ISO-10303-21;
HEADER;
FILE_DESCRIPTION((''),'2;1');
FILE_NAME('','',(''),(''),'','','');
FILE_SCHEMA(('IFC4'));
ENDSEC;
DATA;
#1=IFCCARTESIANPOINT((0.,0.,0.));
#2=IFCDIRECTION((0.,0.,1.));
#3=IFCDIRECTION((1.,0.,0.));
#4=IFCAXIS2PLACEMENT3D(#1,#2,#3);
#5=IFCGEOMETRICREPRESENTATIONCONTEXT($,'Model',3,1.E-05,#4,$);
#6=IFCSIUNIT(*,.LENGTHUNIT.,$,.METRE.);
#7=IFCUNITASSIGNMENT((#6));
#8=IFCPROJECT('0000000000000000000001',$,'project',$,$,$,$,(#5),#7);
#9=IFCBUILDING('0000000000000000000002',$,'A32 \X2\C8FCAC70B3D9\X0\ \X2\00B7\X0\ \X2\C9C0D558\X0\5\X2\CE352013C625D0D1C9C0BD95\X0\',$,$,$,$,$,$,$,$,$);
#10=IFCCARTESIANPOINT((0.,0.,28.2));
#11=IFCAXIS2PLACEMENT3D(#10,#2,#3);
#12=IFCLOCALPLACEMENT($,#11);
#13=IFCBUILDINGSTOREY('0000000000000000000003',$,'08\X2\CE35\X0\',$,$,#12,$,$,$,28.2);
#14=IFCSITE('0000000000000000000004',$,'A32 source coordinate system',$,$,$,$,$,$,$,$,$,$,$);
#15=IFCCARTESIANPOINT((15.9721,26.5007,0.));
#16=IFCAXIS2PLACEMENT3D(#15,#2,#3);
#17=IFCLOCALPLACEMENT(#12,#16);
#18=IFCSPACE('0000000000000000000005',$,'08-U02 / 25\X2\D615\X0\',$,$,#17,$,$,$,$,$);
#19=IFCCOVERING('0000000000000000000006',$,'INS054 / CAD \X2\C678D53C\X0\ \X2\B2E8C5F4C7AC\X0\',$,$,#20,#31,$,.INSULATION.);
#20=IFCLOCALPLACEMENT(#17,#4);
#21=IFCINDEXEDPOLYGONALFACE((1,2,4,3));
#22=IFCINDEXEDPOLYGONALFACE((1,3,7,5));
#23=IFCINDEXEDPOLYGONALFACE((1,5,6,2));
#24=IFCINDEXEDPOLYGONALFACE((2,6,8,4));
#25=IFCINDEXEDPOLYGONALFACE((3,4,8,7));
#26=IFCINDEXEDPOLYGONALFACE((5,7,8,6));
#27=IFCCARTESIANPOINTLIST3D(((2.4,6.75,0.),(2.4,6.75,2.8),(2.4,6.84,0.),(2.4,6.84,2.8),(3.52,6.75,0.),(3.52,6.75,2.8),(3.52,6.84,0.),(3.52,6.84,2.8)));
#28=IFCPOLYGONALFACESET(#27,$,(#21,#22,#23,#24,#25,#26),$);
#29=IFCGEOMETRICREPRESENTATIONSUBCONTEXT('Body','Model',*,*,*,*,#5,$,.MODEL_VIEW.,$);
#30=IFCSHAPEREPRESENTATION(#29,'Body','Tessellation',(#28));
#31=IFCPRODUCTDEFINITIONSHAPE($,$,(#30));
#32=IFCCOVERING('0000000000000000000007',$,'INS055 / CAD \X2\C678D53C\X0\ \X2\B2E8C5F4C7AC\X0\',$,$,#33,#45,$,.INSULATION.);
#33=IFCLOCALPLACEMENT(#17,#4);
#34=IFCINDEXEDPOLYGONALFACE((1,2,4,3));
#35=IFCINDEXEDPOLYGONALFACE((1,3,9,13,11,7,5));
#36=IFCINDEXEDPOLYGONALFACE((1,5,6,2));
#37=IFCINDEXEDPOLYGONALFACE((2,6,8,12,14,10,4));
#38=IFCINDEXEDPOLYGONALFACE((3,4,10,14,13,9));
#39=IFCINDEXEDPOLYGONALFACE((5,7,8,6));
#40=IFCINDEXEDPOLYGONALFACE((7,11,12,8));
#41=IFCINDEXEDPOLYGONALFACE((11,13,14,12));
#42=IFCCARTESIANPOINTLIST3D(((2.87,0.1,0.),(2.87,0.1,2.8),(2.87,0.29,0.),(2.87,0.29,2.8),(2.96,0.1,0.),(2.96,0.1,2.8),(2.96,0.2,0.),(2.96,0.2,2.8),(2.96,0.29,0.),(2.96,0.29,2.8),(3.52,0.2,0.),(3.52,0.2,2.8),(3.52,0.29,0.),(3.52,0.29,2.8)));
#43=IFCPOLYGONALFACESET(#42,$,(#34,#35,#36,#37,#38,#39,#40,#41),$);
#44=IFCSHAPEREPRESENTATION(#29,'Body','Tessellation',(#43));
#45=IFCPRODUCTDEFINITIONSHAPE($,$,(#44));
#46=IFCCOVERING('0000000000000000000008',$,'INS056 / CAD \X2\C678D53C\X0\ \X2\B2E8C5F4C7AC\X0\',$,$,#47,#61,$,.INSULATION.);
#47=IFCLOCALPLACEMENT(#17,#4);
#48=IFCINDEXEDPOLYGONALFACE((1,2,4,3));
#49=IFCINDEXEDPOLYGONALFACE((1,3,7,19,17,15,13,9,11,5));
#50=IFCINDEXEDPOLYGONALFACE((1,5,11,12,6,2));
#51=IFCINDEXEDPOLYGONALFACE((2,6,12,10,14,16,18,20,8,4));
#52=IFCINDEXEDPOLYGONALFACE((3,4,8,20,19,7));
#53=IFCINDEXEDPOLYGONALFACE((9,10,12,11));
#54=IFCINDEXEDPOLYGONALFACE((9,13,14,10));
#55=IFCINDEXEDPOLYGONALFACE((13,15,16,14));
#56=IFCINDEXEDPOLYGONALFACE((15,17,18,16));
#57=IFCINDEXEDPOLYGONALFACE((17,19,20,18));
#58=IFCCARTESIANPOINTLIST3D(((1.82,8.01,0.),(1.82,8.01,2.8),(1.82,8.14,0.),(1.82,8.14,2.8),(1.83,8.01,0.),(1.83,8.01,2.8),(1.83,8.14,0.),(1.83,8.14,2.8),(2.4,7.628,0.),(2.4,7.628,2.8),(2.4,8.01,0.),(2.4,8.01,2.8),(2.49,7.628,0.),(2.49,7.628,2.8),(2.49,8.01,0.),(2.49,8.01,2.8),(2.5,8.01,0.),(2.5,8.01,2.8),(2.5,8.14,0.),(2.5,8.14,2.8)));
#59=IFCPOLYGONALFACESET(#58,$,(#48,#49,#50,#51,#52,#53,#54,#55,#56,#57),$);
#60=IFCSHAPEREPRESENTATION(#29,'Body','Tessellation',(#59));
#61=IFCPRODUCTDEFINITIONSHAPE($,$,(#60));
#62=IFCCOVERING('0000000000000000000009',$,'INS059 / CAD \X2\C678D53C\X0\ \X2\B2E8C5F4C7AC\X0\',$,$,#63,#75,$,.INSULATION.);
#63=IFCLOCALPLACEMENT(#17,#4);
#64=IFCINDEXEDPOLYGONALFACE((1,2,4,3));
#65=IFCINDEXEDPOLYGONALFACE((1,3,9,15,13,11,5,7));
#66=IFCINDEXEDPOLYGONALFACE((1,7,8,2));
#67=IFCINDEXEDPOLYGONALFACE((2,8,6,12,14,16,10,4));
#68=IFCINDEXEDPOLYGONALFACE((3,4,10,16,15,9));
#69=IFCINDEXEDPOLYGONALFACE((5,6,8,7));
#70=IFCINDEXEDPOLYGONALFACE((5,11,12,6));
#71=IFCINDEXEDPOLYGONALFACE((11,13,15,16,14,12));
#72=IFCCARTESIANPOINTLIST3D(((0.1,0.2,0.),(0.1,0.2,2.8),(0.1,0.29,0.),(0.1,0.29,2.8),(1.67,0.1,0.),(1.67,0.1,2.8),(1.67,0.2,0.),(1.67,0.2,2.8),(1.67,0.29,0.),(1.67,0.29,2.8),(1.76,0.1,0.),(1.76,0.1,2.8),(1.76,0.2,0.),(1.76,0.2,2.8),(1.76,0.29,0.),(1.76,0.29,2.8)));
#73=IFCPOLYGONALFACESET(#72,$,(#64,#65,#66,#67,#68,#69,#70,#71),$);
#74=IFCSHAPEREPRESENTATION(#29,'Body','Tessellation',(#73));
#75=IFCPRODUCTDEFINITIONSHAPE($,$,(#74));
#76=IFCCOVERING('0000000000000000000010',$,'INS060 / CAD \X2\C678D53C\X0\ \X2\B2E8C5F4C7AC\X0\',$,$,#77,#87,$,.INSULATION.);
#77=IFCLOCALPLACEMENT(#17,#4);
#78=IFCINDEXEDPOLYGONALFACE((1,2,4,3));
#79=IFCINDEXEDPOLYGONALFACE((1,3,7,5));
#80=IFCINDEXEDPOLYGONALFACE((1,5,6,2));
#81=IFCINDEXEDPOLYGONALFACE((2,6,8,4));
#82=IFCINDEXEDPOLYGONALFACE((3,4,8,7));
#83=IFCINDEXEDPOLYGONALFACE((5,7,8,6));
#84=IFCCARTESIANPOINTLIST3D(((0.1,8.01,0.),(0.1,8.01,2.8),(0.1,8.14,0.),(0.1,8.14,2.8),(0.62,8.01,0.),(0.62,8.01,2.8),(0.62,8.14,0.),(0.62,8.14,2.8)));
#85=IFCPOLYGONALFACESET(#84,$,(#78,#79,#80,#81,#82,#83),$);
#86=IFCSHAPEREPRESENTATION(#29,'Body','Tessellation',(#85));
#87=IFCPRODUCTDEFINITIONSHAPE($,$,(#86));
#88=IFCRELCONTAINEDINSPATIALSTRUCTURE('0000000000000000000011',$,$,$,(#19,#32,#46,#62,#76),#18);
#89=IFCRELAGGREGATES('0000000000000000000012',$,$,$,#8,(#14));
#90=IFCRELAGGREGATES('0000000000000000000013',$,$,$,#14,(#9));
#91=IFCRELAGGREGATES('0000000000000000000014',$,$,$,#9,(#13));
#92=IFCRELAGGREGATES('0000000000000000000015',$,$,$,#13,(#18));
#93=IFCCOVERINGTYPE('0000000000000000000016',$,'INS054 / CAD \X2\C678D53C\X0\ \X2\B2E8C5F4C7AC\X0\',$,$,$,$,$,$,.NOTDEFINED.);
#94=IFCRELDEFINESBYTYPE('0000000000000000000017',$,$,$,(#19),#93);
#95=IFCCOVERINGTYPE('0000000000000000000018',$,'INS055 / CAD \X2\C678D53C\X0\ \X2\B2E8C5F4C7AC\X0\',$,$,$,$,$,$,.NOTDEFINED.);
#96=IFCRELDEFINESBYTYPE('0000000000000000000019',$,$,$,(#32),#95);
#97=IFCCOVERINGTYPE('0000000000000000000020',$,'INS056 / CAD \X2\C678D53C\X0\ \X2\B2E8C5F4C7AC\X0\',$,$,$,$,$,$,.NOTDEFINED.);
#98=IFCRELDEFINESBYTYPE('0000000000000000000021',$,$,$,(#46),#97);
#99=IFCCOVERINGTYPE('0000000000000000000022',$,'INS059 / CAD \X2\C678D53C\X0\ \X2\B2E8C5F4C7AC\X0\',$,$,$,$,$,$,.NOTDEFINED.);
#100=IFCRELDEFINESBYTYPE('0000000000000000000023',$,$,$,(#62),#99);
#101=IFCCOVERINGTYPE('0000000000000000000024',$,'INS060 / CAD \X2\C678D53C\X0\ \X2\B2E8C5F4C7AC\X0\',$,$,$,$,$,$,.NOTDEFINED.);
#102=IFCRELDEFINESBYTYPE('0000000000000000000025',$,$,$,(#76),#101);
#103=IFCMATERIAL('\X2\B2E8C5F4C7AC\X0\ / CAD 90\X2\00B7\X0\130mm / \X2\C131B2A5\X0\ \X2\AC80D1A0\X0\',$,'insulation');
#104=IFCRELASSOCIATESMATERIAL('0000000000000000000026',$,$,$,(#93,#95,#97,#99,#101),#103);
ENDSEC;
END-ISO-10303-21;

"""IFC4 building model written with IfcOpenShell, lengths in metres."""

from ifc_helpers import new_model, si_unit, frame, origin, origin_with_axes, place, context, subcontext, project, spatial, polyline, outline, extrude, source, transform, mapped, material, type_object, type_shapes, element, save


model = new_model("IFC4")

# Units and contexts
model_context = context("Model", 3, precision=1e-05, world=origin_with_axes())
body_context = subcontext(model_context, "Body", "Model", "MODEL_VIEW")
ifc_project = project(units=[si_unit("LENGTHUNIT", "METRE")], contexts=[model_context])

# Site, building, storey, space
storey_placement = place(None, frame((0.0, 0.0, 28.2), z_axis=(0.0, 0.0, 1.0), x_axis=(1.0, 0.0, 0.0)))
space_placement = place(storey_placement, frame((15.9721, 26.5007, 0.0), z_axis=(0.0, 0.0, 1.0), x_axis=(1.0, 0.0, 0.0)))
site = spatial("IfcSite", under=ifc_project, Name="A32 source coordinate system")
building = spatial("IfcBuilding", under=site, Name="A32 주거동 · 지하5층–옥탑지붕")
storey = spatial("IfcBuildingStorey", under=building, at=storey_placement, Name="08층", Elevation=28.2)
space = spatial("IfcSpace", under=storey, at=space_placement, Name="08-U02 / 25형")

# Coverings
ifc_material = material(Name="단열재 / CAD 90·130mm / 성능 검토", Category="insulation")
covering_type_1 = type_object("IfcCoveringType", Name="INS054 / CAD 외피 단열재", PredefinedType="NOTDEFINED", material=ifc_material)
shared_shape_1 = source(origin(), body_context, "Body", "SweptSolid", [
    extrude(outline(polyline([(2.4, 6.84), (3.52, 6.84), (3.52, 6.75), (2.4, 6.75), (2.4, 6.84)])), origin(), (0.0, 0.0, 1.0), 2.8),
])
type_shapes(covering_type_1, [shared_shape_1])
covering_1_placement = place(space_placement, origin_with_axes())
element("IfcCovering", 1, at=covering_1_placement, inside=space, type_object=covering_type_1, Name="INS054 / CAD 외피 단열재", PredefinedType="INSULATION", context=body_context, shape_type="MappedRepresentation", body=[
    mapped(shared_shape_1, transform((0.0, 0.0, 0.0), scale=1.0)),
])
covering_type_2 = type_object("IfcCoveringType", Name="INS055 / CAD 외피 단열재", PredefinedType="NOTDEFINED", material=ifc_material)
shared_shape_2 = source(origin(), body_context, "Body", "SweptSolid", [
    extrude(outline(polyline([(2.87, 0.29), (2.96, 0.29), (3.52, 0.29), (3.52, 0.2), (2.96, 0.2), (2.96, 0.1), (2.87, 0.1), (2.87, 0.29)])), origin(), (0.0, 0.0, 1.0), 2.8),
])
type_shapes(covering_type_2, [shared_shape_2])
covering_2_placement = place(space_placement, origin_with_axes())
element("IfcCovering", 2, at=covering_2_placement, inside=space, type_object=covering_type_2, Name="INS055 / CAD 외피 단열재", PredefinedType="INSULATION", context=body_context, shape_type="MappedRepresentation", body=[
    mapped(shared_shape_2, transform((0.0, 0.0, 0.0), scale=1.0)),
])
covering_type_3 = type_object("IfcCoveringType", Name="INS056 / CAD 외피 단열재", PredefinedType="NOTDEFINED", material=ifc_material)
shared_shape_3 = source(origin(), body_context, "Body", "SweptSolid", [
    extrude(outline(polyline([(2.49, 7.628), (2.4, 7.628), (2.4, 8.01), (1.83, 8.01), (1.82, 8.01), (1.82, 8.14), (1.83, 8.14), (2.5, 8.14), (2.5, 8.01), (2.49, 8.01), (2.49, 7.628)])), origin(), (0.0, 0.0, 1.0), 2.8),
])
type_shapes(covering_type_3, [shared_shape_3])
covering_3_placement = place(space_placement, origin_with_axes())
element("IfcCovering", 3, at=covering_3_placement, inside=space, type_object=covering_type_3, Name="INS056 / CAD 외피 단열재", PredefinedType="INSULATION", context=body_context, shape_type="MappedRepresentation", body=[
    mapped(shared_shape_3, transform((0.0, 0.0, 0.0), scale=1.0)),
])
covering_type_4 = type_object("IfcCoveringType", Name="INS059 / CAD 외피 단열재", PredefinedType="NOTDEFINED", material=ifc_material)
shared_shape_4 = source(origin(), body_context, "Body", "SweptSolid", [
    extrude(outline(polyline([(1.76, 0.1), (1.67, 0.1), (1.67, 0.2), (0.1, 0.2), (0.1, 0.29), (1.67, 0.29), (1.76, 0.29), (1.76, 0.2), (1.76, 0.1)])), origin(), (0.0, 0.0, 1.0), 2.8),
])
type_shapes(covering_type_4, [shared_shape_4])
covering_4_placement = place(space_placement, origin_with_axes())
element("IfcCovering", 4, at=covering_4_placement, inside=space, type_object=covering_type_4, Name="INS059 / CAD 외피 단열재", PredefinedType="INSULATION", context=body_context, shape_type="MappedRepresentation", body=[
    mapped(shared_shape_4, transform((0.0, 0.0, 0.0), scale=1.0)),
])
covering_type_5 = type_object("IfcCoveringType", Name="INS060 / CAD 외피 단열재", PredefinedType="NOTDEFINED", material=ifc_material)
shared_shape_5 = source(origin(), body_context, "Body", "SweptSolid", [
    extrude(outline(polyline([(0.1, 8.01), (0.1, 8.14), (0.62, 8.14), (0.62, 8.01), (0.1, 8.01)])), origin(), (0.0, 0.0, 1.0), 2.8),
])
type_shapes(covering_type_5, [shared_shape_5])
covering_5_placement = place(space_placement, origin_with_axes())
element("IfcCovering", 5, at=covering_5_placement, inside=space, type_object=covering_type_5, Name="INS060 / CAD 외피 단열재", PredefinedType="INSULATION", context=body_context, shape_type="MappedRepresentation", body=[
    mapped(shared_shape_5, transform((0.0, 0.0, 0.0), scale=1.0)),
])

save(model, "model.ifc")
